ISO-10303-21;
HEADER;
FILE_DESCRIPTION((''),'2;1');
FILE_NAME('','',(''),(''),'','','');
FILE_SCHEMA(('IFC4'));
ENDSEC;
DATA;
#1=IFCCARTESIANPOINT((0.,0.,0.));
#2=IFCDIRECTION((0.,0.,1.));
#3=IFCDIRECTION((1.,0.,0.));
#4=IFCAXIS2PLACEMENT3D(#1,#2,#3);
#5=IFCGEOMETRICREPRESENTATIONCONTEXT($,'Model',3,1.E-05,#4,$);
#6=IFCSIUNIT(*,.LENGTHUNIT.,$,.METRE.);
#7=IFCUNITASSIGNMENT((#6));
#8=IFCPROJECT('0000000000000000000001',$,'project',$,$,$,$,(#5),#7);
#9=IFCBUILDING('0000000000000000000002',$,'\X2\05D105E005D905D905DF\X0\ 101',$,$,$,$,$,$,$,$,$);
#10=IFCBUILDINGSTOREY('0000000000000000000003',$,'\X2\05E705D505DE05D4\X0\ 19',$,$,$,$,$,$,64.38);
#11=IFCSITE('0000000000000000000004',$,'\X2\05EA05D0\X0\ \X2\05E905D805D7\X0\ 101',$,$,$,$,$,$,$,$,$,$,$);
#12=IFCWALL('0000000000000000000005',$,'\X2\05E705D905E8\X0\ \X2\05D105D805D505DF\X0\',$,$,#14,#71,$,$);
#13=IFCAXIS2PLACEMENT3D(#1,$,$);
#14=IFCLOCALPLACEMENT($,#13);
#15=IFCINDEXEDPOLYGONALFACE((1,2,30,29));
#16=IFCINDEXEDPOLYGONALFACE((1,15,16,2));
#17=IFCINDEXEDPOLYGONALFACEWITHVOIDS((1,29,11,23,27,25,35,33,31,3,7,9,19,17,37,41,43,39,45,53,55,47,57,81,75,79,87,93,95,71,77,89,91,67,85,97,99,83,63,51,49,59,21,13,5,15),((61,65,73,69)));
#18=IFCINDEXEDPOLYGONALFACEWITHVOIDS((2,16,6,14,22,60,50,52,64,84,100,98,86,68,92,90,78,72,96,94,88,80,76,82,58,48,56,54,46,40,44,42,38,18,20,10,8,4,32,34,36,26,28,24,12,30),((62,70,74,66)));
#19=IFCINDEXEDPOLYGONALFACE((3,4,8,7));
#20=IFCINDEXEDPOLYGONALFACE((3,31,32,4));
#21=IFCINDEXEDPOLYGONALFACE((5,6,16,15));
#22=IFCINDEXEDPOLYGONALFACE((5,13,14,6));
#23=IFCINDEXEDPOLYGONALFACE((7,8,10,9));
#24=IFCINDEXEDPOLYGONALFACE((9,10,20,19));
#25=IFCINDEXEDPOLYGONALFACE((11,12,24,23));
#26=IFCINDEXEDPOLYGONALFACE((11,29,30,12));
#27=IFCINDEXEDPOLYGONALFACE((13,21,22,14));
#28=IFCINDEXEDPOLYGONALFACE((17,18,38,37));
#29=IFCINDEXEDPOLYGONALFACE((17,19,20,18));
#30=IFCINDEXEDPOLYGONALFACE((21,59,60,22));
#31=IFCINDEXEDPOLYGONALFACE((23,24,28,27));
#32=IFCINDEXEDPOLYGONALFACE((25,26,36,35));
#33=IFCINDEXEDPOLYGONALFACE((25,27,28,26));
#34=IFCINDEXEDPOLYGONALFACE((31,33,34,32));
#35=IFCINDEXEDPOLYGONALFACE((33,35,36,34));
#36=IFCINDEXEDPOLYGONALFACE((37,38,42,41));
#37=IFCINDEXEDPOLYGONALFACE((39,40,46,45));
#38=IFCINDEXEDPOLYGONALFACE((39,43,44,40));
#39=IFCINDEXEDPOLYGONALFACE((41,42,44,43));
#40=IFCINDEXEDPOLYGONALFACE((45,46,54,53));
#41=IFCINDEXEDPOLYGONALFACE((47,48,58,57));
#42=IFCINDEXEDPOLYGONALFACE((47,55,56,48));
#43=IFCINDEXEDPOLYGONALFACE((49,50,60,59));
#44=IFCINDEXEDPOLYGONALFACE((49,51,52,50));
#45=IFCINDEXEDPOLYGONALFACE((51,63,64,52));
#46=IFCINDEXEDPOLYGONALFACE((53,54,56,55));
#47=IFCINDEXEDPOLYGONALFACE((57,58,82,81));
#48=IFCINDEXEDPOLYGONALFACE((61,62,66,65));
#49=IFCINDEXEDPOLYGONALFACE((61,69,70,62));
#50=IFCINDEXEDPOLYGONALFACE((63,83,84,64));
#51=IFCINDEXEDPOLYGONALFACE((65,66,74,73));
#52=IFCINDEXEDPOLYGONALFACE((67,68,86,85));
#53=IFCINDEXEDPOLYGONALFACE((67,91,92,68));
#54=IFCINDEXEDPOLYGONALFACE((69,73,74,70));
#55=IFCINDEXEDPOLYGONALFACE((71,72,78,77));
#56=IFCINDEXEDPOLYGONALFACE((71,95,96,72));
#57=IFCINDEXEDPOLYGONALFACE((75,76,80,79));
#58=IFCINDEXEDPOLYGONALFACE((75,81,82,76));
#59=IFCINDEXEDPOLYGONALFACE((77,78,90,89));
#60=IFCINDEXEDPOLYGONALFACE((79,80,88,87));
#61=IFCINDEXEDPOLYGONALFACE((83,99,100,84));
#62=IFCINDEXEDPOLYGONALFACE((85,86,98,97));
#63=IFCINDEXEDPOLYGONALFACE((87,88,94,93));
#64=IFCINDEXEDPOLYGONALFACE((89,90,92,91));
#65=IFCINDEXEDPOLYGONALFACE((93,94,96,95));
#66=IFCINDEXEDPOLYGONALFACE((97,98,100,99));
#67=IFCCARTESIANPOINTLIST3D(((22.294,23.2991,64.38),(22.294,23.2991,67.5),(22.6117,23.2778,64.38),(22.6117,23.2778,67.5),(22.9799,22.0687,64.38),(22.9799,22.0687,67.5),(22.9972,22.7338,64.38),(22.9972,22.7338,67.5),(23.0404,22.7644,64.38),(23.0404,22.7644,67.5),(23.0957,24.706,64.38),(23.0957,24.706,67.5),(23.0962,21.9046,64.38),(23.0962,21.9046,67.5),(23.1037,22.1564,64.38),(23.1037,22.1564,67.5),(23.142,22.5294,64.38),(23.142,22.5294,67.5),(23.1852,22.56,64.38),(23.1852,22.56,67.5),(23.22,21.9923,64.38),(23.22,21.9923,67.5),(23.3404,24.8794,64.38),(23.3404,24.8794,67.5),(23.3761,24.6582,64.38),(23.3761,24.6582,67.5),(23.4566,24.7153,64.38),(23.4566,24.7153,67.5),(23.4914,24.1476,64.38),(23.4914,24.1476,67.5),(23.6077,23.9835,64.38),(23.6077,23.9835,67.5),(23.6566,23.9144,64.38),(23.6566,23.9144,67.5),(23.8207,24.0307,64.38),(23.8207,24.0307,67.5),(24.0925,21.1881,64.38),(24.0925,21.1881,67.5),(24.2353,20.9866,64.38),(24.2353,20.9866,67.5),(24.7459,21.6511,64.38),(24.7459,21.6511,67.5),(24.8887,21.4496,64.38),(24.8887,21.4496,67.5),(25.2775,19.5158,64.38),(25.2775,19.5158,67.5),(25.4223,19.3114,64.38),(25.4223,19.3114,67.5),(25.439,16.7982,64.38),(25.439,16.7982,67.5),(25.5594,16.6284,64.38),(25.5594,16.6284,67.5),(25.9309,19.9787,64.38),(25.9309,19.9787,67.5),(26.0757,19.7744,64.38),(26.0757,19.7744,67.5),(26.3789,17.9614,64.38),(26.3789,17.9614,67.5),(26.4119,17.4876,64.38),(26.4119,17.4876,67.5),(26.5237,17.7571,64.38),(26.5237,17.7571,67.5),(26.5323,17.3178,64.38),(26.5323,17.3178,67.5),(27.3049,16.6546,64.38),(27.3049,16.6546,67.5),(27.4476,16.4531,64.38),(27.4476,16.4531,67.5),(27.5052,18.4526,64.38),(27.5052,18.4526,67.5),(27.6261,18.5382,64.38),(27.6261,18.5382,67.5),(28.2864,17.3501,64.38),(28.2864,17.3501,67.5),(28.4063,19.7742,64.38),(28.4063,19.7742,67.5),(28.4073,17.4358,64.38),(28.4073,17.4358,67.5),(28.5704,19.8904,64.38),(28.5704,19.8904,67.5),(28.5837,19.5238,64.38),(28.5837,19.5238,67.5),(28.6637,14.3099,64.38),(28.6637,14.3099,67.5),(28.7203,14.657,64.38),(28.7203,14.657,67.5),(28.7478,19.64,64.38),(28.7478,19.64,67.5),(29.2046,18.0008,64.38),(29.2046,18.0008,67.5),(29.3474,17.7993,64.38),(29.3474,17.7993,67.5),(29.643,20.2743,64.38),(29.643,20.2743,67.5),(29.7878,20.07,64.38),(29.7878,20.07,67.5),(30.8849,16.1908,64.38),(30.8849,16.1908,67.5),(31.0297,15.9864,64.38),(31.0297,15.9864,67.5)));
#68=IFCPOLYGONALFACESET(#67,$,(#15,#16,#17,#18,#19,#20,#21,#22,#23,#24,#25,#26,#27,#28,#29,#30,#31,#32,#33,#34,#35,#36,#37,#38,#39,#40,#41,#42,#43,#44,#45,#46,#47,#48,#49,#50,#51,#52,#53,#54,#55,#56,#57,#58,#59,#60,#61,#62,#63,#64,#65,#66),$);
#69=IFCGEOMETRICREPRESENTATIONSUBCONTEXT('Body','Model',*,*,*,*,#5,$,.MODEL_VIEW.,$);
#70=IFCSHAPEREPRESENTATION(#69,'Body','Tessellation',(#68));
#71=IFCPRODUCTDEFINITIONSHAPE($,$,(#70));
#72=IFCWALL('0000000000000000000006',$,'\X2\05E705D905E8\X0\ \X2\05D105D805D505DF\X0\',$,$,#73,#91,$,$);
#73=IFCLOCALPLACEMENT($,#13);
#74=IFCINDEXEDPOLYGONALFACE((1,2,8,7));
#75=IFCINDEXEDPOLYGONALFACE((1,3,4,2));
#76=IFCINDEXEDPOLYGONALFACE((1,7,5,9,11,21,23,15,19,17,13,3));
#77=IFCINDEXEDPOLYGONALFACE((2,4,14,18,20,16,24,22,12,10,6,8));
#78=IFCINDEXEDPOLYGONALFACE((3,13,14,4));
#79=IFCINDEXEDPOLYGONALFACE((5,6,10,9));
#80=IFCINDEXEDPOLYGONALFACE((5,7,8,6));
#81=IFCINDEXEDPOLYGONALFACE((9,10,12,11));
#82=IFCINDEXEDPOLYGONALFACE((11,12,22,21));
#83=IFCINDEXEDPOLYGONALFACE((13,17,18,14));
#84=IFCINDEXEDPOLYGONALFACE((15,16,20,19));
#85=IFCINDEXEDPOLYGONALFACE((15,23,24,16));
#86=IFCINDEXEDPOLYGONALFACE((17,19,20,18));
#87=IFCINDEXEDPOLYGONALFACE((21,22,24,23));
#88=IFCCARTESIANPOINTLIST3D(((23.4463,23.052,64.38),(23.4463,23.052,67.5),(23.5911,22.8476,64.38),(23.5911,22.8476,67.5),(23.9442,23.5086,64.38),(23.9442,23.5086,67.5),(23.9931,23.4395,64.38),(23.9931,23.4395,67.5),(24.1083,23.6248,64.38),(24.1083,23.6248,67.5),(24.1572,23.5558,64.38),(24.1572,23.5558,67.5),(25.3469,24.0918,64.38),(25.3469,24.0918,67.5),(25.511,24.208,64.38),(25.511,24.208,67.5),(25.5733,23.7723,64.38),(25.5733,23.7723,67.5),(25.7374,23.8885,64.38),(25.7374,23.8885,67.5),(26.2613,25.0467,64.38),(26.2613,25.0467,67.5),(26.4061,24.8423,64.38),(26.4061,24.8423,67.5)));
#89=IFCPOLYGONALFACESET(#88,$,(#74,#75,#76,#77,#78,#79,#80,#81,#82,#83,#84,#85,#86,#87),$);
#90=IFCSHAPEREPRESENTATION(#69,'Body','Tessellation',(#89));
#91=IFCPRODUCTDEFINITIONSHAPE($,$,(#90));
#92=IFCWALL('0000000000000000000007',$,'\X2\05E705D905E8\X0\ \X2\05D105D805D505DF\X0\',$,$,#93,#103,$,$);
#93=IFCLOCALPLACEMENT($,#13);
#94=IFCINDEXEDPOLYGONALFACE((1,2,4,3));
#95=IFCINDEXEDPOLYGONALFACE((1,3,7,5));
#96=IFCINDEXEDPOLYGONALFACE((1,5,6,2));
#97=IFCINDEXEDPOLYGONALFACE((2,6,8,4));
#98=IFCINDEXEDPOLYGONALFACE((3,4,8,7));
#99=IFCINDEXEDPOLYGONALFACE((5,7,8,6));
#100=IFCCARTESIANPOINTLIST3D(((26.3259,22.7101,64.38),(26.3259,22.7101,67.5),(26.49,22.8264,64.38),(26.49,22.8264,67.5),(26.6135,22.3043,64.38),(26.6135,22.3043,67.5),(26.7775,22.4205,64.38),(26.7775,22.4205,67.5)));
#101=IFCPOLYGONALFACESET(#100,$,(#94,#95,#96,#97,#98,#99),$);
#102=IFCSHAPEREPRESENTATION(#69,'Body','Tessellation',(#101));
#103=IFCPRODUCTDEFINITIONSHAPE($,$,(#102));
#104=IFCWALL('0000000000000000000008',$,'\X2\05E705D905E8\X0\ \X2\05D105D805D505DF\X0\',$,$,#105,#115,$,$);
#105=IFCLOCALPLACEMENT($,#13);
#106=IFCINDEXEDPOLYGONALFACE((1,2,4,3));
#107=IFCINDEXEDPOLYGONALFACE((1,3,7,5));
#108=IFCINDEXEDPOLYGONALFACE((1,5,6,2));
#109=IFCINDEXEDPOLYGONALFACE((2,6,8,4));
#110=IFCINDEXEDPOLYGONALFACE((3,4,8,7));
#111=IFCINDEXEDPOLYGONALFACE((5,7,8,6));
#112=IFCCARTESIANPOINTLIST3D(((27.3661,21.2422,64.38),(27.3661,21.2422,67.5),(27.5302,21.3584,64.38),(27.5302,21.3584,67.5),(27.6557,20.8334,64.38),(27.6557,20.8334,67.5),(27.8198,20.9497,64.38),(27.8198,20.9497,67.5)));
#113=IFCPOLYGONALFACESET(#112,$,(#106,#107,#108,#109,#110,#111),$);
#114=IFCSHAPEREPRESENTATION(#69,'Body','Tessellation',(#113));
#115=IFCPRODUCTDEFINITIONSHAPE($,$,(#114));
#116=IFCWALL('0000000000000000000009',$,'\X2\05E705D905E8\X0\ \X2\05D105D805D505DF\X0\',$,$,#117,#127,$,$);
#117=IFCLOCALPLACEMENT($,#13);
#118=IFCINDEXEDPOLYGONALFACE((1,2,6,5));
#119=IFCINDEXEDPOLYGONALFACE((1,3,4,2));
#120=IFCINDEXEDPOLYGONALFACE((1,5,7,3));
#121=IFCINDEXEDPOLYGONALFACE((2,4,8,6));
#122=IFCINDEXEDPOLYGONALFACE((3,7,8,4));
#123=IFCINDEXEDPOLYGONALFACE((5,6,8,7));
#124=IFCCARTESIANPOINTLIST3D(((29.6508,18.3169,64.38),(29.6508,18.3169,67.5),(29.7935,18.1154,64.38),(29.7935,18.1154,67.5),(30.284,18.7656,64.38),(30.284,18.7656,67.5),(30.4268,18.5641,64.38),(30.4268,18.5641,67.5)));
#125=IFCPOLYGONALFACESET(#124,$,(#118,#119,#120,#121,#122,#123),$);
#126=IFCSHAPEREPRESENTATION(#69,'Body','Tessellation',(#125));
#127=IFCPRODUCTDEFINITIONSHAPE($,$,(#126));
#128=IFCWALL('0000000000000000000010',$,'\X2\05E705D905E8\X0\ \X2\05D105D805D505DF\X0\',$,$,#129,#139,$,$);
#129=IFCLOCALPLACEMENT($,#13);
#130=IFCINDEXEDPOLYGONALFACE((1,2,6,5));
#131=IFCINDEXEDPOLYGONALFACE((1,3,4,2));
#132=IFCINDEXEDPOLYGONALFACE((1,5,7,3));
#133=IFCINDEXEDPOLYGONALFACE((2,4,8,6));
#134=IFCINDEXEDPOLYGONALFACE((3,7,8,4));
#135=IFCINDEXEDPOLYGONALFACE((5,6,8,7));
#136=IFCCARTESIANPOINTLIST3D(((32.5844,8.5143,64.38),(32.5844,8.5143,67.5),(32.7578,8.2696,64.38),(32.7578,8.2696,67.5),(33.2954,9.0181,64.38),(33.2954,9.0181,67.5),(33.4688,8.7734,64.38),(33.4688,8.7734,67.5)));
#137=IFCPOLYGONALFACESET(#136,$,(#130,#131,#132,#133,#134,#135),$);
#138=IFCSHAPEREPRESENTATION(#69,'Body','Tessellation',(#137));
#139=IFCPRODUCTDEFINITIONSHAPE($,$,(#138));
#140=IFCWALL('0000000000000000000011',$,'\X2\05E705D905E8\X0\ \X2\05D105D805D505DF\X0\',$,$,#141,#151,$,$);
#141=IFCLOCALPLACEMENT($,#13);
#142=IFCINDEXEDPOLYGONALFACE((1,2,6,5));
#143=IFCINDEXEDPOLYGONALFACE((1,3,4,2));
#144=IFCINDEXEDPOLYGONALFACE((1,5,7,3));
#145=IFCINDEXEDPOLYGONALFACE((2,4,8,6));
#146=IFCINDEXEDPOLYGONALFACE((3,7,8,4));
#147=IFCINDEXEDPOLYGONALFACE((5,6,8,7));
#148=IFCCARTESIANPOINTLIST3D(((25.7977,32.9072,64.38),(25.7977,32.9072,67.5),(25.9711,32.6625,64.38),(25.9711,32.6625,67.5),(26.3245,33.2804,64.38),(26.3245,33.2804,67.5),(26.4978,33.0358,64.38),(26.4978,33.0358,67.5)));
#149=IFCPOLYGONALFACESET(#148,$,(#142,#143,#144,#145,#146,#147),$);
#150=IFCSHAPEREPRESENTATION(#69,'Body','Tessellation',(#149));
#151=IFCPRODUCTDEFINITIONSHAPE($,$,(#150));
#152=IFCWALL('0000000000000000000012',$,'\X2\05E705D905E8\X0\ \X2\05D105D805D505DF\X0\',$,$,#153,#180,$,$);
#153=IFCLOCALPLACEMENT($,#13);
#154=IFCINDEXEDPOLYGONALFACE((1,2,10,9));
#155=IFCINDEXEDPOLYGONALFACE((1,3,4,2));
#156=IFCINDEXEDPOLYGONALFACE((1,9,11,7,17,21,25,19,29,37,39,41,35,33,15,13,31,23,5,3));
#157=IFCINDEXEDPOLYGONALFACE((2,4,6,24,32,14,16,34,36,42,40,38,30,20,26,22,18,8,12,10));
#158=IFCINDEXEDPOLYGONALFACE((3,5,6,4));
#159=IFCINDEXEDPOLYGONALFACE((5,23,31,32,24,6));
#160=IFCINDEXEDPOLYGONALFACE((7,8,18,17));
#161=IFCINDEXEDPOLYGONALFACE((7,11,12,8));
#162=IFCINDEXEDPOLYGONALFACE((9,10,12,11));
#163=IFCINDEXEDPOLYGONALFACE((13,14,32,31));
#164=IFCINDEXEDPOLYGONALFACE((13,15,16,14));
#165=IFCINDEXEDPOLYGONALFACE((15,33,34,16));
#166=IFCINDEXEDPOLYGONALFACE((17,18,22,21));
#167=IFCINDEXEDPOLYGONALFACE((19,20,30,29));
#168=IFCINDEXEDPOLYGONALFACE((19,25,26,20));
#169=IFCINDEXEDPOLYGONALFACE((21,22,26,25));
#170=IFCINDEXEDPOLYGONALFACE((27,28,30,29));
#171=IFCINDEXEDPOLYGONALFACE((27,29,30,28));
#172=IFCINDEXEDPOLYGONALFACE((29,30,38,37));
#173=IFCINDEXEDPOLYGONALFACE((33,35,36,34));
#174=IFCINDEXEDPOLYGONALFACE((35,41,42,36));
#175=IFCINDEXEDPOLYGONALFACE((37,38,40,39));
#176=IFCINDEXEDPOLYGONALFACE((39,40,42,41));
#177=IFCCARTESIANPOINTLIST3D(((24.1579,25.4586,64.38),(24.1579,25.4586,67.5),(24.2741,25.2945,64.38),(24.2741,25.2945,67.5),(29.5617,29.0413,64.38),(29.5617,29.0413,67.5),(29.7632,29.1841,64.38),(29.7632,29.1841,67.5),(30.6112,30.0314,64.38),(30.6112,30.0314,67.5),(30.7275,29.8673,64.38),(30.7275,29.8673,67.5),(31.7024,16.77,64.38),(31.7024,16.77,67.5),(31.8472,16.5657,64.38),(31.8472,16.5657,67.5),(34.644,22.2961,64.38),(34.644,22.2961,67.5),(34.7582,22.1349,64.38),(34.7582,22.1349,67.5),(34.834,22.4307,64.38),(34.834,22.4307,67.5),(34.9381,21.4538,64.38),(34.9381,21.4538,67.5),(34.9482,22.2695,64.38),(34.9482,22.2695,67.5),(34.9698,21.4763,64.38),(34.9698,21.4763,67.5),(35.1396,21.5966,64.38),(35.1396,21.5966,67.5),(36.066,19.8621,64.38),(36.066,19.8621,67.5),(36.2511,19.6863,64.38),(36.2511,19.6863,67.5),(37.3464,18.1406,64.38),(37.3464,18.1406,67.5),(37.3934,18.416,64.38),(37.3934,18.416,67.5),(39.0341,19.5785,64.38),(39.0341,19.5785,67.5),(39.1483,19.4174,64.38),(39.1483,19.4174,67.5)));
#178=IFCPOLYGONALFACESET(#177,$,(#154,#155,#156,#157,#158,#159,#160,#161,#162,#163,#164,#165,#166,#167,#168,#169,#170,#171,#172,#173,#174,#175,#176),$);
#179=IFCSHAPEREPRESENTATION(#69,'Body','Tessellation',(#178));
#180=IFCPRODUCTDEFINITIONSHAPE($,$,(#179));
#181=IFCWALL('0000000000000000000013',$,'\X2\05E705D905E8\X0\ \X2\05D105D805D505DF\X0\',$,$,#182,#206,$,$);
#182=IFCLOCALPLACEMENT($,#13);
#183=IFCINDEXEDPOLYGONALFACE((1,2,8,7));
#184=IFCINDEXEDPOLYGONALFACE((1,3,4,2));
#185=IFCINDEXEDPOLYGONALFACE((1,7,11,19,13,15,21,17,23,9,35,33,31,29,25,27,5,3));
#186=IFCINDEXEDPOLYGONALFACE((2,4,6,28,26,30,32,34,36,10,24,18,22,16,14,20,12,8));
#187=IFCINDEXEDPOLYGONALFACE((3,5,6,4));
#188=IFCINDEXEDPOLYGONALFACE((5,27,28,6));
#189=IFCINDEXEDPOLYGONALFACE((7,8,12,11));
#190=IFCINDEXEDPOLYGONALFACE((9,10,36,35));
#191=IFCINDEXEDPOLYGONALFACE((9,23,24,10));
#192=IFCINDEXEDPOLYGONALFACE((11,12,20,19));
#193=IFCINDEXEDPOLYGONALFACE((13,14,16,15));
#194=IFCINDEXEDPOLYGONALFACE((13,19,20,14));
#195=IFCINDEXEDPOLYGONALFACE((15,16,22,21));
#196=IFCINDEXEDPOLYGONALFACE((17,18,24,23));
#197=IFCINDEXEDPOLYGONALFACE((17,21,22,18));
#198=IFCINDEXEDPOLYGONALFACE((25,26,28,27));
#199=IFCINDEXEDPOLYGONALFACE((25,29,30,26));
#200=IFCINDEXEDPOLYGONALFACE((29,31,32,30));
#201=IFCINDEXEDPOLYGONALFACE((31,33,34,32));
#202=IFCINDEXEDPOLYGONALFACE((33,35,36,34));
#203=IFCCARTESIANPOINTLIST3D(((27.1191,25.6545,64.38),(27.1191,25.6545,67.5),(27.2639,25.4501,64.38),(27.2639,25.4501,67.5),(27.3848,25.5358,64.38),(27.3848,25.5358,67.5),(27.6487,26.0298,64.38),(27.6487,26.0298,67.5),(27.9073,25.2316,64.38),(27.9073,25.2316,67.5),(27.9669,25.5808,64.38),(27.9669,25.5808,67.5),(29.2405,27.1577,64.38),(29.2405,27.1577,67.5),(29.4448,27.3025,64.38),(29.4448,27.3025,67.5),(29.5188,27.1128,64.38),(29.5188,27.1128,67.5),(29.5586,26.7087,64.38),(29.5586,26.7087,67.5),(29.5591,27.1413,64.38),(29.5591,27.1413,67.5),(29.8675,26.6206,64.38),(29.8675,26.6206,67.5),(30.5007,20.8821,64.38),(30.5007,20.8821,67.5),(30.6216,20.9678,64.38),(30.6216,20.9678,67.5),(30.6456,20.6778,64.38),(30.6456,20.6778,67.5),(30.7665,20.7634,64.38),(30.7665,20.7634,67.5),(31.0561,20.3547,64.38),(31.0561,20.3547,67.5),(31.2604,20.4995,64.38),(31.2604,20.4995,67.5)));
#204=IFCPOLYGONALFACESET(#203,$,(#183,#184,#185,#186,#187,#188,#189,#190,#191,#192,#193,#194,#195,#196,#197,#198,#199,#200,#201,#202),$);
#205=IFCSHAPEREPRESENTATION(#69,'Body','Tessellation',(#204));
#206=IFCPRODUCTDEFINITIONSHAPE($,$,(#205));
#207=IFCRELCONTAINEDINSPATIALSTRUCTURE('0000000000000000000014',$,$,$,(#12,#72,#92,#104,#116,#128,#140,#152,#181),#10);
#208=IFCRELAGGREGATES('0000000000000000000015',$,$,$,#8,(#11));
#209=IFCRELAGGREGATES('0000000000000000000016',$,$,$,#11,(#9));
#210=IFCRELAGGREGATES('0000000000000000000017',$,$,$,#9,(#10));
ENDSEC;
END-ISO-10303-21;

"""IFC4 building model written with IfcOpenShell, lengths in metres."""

from ifc_helpers import new_model, si_unit, frame, origin_with_axes, context, subcontext, project, spatial, polyline, outline, extrude, element, save


model = new_model("IFC4")

# Units and contexts
model_context = context("Model", 3, precision=1e-05, world=origin_with_axes())
body_context = subcontext(model_context, "Body", "Model", "MODEL_VIEW")
ifc_project = project(units=[si_unit("LENGTHUNIT", "METRE")], contexts=[model_context])

# Site, building, storey
site = spatial("IfcSite", under=ifc_project, Name="תא שטח 101")
building = spatial("IfcBuilding", under=site, Name="בניין 101")
storey = spatial("IfcBuildingStorey", under=building, Name="קומה 19", Elevation=64.38)

# Walls
element("IfcWall", 1, inside=storey, Name="קיר בטון", context=body_context, shape_type="SweptSolid", body=[
    extrude(outline(polyline([(22.294, 23.2991), (23.1037, 22.1564), (22.9799, 22.0687), (23.0962, 21.9046), (23.22, 21.9923), (26.4119, 17.4876), (25.439, 16.7982), (25.5594, 16.6284), (26.5323, 17.3178), (28.6637, 14.3099), (31.0297, 15.9864), (30.8849, 16.1908), (28.7203, 14.657), (27.4476, 16.4531), (29.3474, 17.7993), (29.2046, 18.0008), (28.4073, 17.4358), (27.6261, 18.5382), (29.7878, 20.07), (29.643, 20.2743), (28.7478, 19.64), (28.5704, 19.8904), (28.4063, 19.7742), (28.5837, 19.5238), (26.3789, 17.9614), (25.4223, 19.3114), (26.0757, 19.7744), (25.9309, 19.9787), (25.2775, 19.5158), (24.2353, 20.9866), (24.8887, 21.4496), (24.7459, 21.6511), (24.0925, 21.1881), (23.142, 22.5294), (23.1852, 22.56), (23.0404, 22.7644), (22.9972, 22.7338), (22.6117, 23.2778), (23.6077, 23.9835), (23.6566, 23.9144), (23.8207, 24.0307), (23.3761, 24.6582), (23.4566, 24.7153), (23.3404, 24.8794), (23.0957, 24.706), (23.4914, 24.1476), (22.294, 23.2991)]), holes=[polyline([(27.3049, 16.6546), (26.5237, 17.7571), (27.5052, 18.4526), (28.2864, 17.3501), (27.3049, 16.6546)])]), frame((0.0, 0.0, 64.38)), (0.0, 0.0, 1.0), 3.12),
])
element("IfcWall", 2, inside=storey, Name="קיר בטון", context=body_context, shape_type="SweptSolid", body=[
    extrude(outline(polyline([(25.3469, 24.0918), (25.5733, 23.7723), (25.7374, 23.8885), (25.511, 24.208), (26.4061, 24.8423), (26.2613, 25.0467), (24.1572, 23.5558), (24.1083, 23.6248), (23.9442, 23.5086), (23.9931, 23.4395), (23.4463, 23.052), (23.5911, 22.8476), (25.3469, 24.0918)])), frame((0.0, 0.0, 64.38)), (0.0, 0.0, 1.0), 3.12),
])
element("IfcWall", 3, inside=storey, Name="קיר בטון", context=body_context, shape_type="SweptSolid", body=[
    extrude(outline(polyline([(26.49, 22.8264), (26.3259, 22.7101), (26.6135, 22.3043), (26.7775, 22.4205), (26.49, 22.8264)])), frame((0.0, 0.0, 64.38)), (0.0, 0.0, 1.0), 3.12),
])
element("IfcWall", 4, inside=storey, Name="קיר בטון", context=body_context, shape_type="SweptSolid", body=[
    extrude(outline(polyline([(27.6557, 20.8334), (27.8198, 20.9497), (27.5302, 21.3584), (27.3661, 21.2422), (27.6557, 20.8334)])), frame((0.0, 0.0, 64.38)), (0.0, 0.0, 1.0), 3.12),
])
element("IfcWall", 5, inside=storey, Name="קיר בטון", context=body_context, shape_type="SweptSolid", body=[
    extrude(outline(polyline([(30.284, 18.7656), (29.6508, 18.3169), (29.7935, 18.1154), (30.4268, 18.5641), (30.284, 18.7656)])), frame((0.0, 0.0, 64.38)), (0.0, 0.0, 1.0), 3.12),
])
element("IfcWall", 6, inside=storey, Name="קיר בטון", context=body_context, shape_type="SweptSolid", body=[
    extrude(outline(polyline([(33.2954, 9.0181), (32.5844, 8.5143), (32.7578, 8.2696), (33.4688, 8.7734), (33.2954, 9.0181)])), frame((0.0, 0.0, 64.38)), (0.0, 0.0, 1.0), 3.12),
])
element("IfcWall", 7, inside=storey, Name="קיר בטון", context=body_context, shape_type="SweptSolid", body=[
    extrude(outline(polyline([(25.7977, 32.9072), (25.9711, 32.6625), (26.4978, 33.0358), (26.3245, 33.2804), (25.7977, 32.9072)])), frame((0.0, 0.0, 64.38)), (0.0, 0.0, 1.0), 3.12),
])
element("IfcWall", 8, inside=storey, Name="קיר בטון", context=body_context, shape_type="SweptSolid", body=[
    extrude(outline(polyline([(30.6112, 30.0314), (24.1579, 25.4586), (24.2741, 25.2945), (29.5617, 29.0413), (34.9381, 21.4538), (36.066, 19.8621), (31.7024, 16.77), (31.8472, 16.5657), (36.2511, 19.6863), (37.3464, 18.1406), (39.1483, 19.4174), (39.0341, 19.5785), (37.3934, 18.416), (35.1396, 21.5966), (34.9698, 21.4763), (35.1396, 21.5966), (34.7582, 22.1349), (34.9482, 22.2695), (34.834, 22.4307), (34.644, 22.2961), (29.7632, 29.1841), (30.7275, 29.8673), (30.6112, 30.0314)])), frame((0.0, 0.0, 64.38)), (0.0, 0.0, 1.0), 3.12),
])
element("IfcWall", 9, inside=storey, Name="קיר בטון", context=body_context, shape_type="SweptSolid", body=[
    extrude(outline(polyline([(27.6487, 26.0298), (27.1191, 25.6545), (27.2639, 25.4501), (27.3848, 25.5358), (30.6216, 20.9678), (30.5007, 20.8821), (30.6456, 20.6778), (30.7665, 20.7634), (31.0561, 20.3547), (31.2604, 20.4995), (27.9073, 25.2316), (29.8675, 26.6206), (29.5188, 27.1128), (29.5591, 27.1413), (29.4448, 27.3025), (29.2405, 27.1577), (29.5586, 26.7087), (27.9669, 25.5808), (27.6487, 26.0298)])), frame((0.0, 0.0, 64.38)), (0.0, 0.0, 1.0), 3.12),
])

save(model, "model.ifc")
